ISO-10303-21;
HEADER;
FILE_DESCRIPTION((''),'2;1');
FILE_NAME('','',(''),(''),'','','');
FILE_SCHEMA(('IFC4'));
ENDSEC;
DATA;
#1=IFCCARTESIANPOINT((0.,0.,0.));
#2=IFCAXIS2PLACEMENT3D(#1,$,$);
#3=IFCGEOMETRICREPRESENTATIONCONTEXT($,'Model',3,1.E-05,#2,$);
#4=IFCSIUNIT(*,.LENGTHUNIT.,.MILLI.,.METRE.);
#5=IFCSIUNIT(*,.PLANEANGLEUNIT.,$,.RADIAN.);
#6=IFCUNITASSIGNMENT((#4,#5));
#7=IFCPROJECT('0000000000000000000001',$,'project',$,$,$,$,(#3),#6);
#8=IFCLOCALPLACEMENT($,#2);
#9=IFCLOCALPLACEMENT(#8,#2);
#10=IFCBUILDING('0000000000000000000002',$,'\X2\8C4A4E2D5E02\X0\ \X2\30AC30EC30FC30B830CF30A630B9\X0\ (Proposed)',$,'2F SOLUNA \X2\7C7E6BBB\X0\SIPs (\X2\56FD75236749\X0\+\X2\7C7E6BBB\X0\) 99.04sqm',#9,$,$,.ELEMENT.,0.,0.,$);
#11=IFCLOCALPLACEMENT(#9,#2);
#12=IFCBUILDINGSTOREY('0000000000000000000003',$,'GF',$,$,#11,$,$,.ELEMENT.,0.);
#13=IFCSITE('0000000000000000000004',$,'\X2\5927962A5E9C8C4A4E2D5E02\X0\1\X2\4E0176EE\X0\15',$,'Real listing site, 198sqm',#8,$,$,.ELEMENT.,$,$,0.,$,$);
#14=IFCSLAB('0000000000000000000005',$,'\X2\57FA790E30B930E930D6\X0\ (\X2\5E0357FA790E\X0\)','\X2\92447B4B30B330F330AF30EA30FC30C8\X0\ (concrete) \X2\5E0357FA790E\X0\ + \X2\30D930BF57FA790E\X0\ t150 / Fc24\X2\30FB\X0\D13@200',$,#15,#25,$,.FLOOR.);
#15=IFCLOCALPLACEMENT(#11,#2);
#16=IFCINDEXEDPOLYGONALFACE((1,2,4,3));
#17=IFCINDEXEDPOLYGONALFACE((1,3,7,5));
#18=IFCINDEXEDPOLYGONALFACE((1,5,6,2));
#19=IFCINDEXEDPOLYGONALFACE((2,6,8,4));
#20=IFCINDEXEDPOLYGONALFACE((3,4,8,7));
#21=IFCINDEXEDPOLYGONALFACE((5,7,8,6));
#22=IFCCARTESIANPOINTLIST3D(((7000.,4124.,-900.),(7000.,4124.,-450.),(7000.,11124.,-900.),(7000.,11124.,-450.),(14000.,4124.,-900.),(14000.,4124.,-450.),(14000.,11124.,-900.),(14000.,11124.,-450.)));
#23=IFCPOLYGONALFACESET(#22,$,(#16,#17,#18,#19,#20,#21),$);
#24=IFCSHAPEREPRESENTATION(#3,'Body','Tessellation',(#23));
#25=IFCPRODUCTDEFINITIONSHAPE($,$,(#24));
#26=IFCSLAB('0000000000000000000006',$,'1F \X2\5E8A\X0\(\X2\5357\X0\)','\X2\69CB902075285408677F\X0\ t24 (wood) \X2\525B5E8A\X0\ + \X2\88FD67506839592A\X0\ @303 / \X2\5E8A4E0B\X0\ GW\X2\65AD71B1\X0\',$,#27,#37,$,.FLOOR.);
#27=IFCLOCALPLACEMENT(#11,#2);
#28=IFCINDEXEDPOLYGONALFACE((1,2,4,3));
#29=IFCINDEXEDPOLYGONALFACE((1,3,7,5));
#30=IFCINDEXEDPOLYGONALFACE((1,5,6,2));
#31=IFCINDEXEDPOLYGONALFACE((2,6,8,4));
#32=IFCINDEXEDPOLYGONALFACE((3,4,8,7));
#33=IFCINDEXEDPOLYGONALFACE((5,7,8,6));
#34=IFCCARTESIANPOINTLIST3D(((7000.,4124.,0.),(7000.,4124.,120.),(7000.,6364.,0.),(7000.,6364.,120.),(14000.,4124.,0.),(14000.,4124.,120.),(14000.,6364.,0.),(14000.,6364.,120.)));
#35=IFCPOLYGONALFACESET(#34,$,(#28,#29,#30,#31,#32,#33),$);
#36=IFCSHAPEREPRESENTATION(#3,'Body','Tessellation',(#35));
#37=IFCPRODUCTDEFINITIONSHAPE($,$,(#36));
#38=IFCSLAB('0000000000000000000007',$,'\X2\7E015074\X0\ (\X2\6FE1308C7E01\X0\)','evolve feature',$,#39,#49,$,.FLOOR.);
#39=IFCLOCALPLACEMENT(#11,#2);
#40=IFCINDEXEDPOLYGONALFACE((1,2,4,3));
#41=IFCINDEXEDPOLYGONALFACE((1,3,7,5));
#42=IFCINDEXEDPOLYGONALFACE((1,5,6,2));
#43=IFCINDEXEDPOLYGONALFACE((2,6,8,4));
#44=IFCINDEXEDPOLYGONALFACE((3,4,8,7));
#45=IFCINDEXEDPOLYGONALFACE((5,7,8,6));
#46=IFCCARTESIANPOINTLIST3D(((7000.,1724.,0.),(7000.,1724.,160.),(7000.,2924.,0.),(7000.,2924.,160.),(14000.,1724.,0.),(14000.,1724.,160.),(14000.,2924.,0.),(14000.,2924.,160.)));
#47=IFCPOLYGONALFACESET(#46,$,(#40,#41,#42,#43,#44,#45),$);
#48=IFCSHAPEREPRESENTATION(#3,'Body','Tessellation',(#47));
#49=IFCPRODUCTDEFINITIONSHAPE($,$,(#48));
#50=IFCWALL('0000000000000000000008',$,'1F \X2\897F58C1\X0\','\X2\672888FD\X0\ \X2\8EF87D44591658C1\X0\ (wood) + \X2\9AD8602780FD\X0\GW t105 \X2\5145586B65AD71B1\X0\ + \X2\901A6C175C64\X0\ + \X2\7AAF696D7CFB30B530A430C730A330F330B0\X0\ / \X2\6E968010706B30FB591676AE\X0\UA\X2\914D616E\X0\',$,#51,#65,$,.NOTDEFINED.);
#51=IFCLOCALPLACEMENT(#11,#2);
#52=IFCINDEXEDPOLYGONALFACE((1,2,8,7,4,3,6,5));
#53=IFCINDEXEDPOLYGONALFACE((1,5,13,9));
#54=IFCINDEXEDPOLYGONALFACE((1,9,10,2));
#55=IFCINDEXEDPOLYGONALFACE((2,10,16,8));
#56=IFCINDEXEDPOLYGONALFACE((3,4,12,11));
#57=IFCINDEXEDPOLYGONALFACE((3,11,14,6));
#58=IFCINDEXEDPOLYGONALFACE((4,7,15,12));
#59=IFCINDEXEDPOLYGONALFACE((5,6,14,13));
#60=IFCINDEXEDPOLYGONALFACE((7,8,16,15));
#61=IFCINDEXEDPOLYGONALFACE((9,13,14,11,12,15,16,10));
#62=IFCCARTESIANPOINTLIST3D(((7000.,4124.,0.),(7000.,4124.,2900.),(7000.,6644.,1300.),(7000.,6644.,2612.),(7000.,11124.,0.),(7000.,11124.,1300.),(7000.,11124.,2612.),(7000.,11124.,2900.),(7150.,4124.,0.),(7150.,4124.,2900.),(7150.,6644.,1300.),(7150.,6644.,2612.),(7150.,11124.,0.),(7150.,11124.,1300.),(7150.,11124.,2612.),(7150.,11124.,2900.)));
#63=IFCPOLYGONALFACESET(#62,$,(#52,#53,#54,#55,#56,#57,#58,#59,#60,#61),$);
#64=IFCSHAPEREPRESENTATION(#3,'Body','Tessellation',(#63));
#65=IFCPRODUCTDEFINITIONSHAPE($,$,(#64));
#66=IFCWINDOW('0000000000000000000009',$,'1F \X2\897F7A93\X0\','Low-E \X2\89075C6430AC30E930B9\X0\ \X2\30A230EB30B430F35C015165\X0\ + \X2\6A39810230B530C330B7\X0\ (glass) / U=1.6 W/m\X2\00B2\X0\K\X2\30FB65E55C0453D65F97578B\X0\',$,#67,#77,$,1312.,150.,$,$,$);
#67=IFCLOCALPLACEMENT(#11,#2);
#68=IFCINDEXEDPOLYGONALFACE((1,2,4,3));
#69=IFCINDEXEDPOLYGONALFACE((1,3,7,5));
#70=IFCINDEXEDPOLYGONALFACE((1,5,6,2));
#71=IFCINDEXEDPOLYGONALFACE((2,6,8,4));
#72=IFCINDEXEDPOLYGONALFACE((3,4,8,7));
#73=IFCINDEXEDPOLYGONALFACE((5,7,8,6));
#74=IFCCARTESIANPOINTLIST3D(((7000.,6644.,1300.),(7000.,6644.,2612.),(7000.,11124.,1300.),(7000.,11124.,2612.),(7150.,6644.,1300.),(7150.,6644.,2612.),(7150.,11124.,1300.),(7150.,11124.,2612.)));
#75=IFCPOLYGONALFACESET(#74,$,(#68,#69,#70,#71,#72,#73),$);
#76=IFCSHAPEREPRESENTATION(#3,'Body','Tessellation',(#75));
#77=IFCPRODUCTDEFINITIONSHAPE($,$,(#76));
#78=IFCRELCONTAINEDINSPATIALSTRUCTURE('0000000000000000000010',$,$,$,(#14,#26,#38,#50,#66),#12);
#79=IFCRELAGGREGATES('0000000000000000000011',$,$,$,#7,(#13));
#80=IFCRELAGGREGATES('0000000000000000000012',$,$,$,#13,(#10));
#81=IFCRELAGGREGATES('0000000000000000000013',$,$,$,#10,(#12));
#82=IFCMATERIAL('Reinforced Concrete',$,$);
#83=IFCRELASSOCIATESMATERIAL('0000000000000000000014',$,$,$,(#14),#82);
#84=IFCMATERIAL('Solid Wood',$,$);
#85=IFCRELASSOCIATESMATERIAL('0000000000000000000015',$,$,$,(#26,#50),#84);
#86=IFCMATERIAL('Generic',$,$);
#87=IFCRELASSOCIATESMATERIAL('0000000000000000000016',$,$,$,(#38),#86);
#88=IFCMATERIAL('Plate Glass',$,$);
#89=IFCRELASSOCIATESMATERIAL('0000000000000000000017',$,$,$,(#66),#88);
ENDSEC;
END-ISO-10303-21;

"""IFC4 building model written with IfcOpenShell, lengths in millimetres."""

from ifc_helpers import new_model, si_unit, frame, frame_2d, origin, place, context, project, spatial, rectangle, extrude, material, element, fill, save


model = new_model("IFC4")

# Units and contexts
model_context = context("Model", 3, precision=1e-05, world=origin())
ifc_project = project(units=[si_unit("LENGTHUNIT", "METRE", prefix="MILLI"), si_unit("PLANEANGLEUNIT", "RADIAN")], contexts=[model_context])

# Site, building, storey
site_placement = place(None, origin())
site = spatial("IfcSite", under=ifc_project, at=site_placement, Name="大阪府豊中市1丁目15", ObjectType="Real listing site, 198sqm", CompositionType="ELEMENT", RefElevation=0.0)
building_placement = place(site_placement, origin())
building = spatial("IfcBuilding", under=site, at=building_placement, Name="豊中市 ガレージハウス (Proposed)", ObjectType="2F SOLUNA 籾殻SIPs (国産杉+籾殻) 99.04sqm", CompositionType="ELEMENT", ElevationOfRefHeight=0.0, ElevationOfTerrain=0.0)
storey_placement = place(building_placement, origin())
storey = spatial("IfcBuildingStorey", under=building, at=storey_placement, Name="GF", CompositionType="ELEMENT", Elevation=0.0)

# Slabs
ifc_material_1 = material(Name="Reinforced Concrete")
slab_1_placement = place(storey_placement, frame((3500.0, 2062.0, -450.0)))
element("IfcSlab", 1, at=slab_1_placement, inside=storey, material=ifc_material_1, Name="基礎スラブ (布基礎)", Description="鉄筋コンクリート (concrete) 布基礎 + ベタ基礎 t150 / Fc24・D13@200", PredefinedType="FLOOR", context=model_context, shape_type="SweptSolid", body=[
    extrude(rectangle(XDim=7000.0, YDim=7000.0, at=frame_2d((3500.0, 3500.0))), frame((3500.0, 2062.0, -450.0)), (0.0, 0.0, 1.0), 450.0),
])
ifc_material_2 = material(Name="Solid Wood")
slab_2_placement = place(storey_placement, frame((3500.0, 2062.0, 0.0)))
element("IfcSlab", 2, at=slab_2_placement, inside=storey, material=ifc_material_2, Name="1F 床(南)", Description="構造用合板 t24 (wood) 剛床 + 製材根太 @303 / 床下 GW断熱", PredefinedType="FLOOR", context=model_context, shape_type="SweptSolid", body=[
    extrude(rectangle(XDim=7000.0, YDim=2240.0, at=frame_2d((3500.0, 1120.0))), frame((3500.0, 2062.0, 0.0)), (0.0, 0.0, 1.0), 120.0),
])
ifc_material_3 = material(Name="Generic")
slab_3_placement = place(storey_placement, frame((3500.0, 862.0, 0.0)))
element("IfcSlab", 3, at=slab_3_placement, inside=storey, material=ifc_material_3, Name="縁側 (濡れ縁)", Description="evolve feature", PredefinedType="FLOOR", context=model_context, shape_type="SweptSolid", body=[
    extrude(rectangle(XDim=7000.0, YDim=1200.0, at=frame_2d((3500.0, 600.0))), frame((3500.0, 862.0, 0.0)), (0.0, 0.0, 1.0), 160.0),
])

# Shared definitions
ifc_material_4 = material(Name="Plate Glass")

# Wall, opening, window
wall_1_placement = place(storey_placement, frame((3500.0, 2062.0, 0.0)))
wall_1 = element("IfcWall", 4, at=wall_1_placement, inside=storey, material=ifc_material_2, Name="1F 西壁", Description="木製 軸組外壁 (wood) + 高性能GW t105 充填断熱 + 通気層 + 窯業系サイディング / 準耐火・外皮UA配慮", PredefinedType="NOTDEFINED", context=model_context, shape_type="SweptSolid", body=[
    extrude(rectangle(XDim=150.0, YDim=7000.0, at=frame_2d((75.0, 3500.0))), frame((3500.0, 2062.0, 0.0)), (0.0, 0.0, 1.0), 2900.0),
])
opening_1_placement = place(storey_placement, frame((3500.0, 3322.0, 650.0)))
opening_1 = element("IfcOpeningElement", 5, at=opening_1_placement, cuts=wall_1, PredefinedType="NOTDEFINED", context=model_context, shape_type="SweptSolid", body=[
    extrude(rectangle(XDim=150.0, YDim=4480.0, at=frame_2d((75.0, 2240.0))), frame((3500.0, 3322.0, 650.0)), (0.0, 0.0, 1.0), 1312.0),
])
window_1_placement = place(storey_placement, frame((3500.0, 3322.0, 650.0)))
window_1 = element("IfcWindow", 6, at=window_1_placement, inside=storey, material=ifc_material_4, Name="1F 西窓", Description="Low-E 複層ガラス アルゴン封入 + 樹脂サッシ (glass) / U=1.6 W/m²K・日射取得型", OverallHeight=1312.0, OverallWidth=150.0, context=model_context, shape_type="SweptSolid", body=[
    extrude(rectangle(XDim=150.0, YDim=4480.0, at=frame_2d((75.0, 2240.0))), frame((3500.0, 3322.0, 650.0)), (0.0, 0.0, 1.0), 1312.0),
])
fill(opening_1, window_1)

save(model, "model.ifc")
